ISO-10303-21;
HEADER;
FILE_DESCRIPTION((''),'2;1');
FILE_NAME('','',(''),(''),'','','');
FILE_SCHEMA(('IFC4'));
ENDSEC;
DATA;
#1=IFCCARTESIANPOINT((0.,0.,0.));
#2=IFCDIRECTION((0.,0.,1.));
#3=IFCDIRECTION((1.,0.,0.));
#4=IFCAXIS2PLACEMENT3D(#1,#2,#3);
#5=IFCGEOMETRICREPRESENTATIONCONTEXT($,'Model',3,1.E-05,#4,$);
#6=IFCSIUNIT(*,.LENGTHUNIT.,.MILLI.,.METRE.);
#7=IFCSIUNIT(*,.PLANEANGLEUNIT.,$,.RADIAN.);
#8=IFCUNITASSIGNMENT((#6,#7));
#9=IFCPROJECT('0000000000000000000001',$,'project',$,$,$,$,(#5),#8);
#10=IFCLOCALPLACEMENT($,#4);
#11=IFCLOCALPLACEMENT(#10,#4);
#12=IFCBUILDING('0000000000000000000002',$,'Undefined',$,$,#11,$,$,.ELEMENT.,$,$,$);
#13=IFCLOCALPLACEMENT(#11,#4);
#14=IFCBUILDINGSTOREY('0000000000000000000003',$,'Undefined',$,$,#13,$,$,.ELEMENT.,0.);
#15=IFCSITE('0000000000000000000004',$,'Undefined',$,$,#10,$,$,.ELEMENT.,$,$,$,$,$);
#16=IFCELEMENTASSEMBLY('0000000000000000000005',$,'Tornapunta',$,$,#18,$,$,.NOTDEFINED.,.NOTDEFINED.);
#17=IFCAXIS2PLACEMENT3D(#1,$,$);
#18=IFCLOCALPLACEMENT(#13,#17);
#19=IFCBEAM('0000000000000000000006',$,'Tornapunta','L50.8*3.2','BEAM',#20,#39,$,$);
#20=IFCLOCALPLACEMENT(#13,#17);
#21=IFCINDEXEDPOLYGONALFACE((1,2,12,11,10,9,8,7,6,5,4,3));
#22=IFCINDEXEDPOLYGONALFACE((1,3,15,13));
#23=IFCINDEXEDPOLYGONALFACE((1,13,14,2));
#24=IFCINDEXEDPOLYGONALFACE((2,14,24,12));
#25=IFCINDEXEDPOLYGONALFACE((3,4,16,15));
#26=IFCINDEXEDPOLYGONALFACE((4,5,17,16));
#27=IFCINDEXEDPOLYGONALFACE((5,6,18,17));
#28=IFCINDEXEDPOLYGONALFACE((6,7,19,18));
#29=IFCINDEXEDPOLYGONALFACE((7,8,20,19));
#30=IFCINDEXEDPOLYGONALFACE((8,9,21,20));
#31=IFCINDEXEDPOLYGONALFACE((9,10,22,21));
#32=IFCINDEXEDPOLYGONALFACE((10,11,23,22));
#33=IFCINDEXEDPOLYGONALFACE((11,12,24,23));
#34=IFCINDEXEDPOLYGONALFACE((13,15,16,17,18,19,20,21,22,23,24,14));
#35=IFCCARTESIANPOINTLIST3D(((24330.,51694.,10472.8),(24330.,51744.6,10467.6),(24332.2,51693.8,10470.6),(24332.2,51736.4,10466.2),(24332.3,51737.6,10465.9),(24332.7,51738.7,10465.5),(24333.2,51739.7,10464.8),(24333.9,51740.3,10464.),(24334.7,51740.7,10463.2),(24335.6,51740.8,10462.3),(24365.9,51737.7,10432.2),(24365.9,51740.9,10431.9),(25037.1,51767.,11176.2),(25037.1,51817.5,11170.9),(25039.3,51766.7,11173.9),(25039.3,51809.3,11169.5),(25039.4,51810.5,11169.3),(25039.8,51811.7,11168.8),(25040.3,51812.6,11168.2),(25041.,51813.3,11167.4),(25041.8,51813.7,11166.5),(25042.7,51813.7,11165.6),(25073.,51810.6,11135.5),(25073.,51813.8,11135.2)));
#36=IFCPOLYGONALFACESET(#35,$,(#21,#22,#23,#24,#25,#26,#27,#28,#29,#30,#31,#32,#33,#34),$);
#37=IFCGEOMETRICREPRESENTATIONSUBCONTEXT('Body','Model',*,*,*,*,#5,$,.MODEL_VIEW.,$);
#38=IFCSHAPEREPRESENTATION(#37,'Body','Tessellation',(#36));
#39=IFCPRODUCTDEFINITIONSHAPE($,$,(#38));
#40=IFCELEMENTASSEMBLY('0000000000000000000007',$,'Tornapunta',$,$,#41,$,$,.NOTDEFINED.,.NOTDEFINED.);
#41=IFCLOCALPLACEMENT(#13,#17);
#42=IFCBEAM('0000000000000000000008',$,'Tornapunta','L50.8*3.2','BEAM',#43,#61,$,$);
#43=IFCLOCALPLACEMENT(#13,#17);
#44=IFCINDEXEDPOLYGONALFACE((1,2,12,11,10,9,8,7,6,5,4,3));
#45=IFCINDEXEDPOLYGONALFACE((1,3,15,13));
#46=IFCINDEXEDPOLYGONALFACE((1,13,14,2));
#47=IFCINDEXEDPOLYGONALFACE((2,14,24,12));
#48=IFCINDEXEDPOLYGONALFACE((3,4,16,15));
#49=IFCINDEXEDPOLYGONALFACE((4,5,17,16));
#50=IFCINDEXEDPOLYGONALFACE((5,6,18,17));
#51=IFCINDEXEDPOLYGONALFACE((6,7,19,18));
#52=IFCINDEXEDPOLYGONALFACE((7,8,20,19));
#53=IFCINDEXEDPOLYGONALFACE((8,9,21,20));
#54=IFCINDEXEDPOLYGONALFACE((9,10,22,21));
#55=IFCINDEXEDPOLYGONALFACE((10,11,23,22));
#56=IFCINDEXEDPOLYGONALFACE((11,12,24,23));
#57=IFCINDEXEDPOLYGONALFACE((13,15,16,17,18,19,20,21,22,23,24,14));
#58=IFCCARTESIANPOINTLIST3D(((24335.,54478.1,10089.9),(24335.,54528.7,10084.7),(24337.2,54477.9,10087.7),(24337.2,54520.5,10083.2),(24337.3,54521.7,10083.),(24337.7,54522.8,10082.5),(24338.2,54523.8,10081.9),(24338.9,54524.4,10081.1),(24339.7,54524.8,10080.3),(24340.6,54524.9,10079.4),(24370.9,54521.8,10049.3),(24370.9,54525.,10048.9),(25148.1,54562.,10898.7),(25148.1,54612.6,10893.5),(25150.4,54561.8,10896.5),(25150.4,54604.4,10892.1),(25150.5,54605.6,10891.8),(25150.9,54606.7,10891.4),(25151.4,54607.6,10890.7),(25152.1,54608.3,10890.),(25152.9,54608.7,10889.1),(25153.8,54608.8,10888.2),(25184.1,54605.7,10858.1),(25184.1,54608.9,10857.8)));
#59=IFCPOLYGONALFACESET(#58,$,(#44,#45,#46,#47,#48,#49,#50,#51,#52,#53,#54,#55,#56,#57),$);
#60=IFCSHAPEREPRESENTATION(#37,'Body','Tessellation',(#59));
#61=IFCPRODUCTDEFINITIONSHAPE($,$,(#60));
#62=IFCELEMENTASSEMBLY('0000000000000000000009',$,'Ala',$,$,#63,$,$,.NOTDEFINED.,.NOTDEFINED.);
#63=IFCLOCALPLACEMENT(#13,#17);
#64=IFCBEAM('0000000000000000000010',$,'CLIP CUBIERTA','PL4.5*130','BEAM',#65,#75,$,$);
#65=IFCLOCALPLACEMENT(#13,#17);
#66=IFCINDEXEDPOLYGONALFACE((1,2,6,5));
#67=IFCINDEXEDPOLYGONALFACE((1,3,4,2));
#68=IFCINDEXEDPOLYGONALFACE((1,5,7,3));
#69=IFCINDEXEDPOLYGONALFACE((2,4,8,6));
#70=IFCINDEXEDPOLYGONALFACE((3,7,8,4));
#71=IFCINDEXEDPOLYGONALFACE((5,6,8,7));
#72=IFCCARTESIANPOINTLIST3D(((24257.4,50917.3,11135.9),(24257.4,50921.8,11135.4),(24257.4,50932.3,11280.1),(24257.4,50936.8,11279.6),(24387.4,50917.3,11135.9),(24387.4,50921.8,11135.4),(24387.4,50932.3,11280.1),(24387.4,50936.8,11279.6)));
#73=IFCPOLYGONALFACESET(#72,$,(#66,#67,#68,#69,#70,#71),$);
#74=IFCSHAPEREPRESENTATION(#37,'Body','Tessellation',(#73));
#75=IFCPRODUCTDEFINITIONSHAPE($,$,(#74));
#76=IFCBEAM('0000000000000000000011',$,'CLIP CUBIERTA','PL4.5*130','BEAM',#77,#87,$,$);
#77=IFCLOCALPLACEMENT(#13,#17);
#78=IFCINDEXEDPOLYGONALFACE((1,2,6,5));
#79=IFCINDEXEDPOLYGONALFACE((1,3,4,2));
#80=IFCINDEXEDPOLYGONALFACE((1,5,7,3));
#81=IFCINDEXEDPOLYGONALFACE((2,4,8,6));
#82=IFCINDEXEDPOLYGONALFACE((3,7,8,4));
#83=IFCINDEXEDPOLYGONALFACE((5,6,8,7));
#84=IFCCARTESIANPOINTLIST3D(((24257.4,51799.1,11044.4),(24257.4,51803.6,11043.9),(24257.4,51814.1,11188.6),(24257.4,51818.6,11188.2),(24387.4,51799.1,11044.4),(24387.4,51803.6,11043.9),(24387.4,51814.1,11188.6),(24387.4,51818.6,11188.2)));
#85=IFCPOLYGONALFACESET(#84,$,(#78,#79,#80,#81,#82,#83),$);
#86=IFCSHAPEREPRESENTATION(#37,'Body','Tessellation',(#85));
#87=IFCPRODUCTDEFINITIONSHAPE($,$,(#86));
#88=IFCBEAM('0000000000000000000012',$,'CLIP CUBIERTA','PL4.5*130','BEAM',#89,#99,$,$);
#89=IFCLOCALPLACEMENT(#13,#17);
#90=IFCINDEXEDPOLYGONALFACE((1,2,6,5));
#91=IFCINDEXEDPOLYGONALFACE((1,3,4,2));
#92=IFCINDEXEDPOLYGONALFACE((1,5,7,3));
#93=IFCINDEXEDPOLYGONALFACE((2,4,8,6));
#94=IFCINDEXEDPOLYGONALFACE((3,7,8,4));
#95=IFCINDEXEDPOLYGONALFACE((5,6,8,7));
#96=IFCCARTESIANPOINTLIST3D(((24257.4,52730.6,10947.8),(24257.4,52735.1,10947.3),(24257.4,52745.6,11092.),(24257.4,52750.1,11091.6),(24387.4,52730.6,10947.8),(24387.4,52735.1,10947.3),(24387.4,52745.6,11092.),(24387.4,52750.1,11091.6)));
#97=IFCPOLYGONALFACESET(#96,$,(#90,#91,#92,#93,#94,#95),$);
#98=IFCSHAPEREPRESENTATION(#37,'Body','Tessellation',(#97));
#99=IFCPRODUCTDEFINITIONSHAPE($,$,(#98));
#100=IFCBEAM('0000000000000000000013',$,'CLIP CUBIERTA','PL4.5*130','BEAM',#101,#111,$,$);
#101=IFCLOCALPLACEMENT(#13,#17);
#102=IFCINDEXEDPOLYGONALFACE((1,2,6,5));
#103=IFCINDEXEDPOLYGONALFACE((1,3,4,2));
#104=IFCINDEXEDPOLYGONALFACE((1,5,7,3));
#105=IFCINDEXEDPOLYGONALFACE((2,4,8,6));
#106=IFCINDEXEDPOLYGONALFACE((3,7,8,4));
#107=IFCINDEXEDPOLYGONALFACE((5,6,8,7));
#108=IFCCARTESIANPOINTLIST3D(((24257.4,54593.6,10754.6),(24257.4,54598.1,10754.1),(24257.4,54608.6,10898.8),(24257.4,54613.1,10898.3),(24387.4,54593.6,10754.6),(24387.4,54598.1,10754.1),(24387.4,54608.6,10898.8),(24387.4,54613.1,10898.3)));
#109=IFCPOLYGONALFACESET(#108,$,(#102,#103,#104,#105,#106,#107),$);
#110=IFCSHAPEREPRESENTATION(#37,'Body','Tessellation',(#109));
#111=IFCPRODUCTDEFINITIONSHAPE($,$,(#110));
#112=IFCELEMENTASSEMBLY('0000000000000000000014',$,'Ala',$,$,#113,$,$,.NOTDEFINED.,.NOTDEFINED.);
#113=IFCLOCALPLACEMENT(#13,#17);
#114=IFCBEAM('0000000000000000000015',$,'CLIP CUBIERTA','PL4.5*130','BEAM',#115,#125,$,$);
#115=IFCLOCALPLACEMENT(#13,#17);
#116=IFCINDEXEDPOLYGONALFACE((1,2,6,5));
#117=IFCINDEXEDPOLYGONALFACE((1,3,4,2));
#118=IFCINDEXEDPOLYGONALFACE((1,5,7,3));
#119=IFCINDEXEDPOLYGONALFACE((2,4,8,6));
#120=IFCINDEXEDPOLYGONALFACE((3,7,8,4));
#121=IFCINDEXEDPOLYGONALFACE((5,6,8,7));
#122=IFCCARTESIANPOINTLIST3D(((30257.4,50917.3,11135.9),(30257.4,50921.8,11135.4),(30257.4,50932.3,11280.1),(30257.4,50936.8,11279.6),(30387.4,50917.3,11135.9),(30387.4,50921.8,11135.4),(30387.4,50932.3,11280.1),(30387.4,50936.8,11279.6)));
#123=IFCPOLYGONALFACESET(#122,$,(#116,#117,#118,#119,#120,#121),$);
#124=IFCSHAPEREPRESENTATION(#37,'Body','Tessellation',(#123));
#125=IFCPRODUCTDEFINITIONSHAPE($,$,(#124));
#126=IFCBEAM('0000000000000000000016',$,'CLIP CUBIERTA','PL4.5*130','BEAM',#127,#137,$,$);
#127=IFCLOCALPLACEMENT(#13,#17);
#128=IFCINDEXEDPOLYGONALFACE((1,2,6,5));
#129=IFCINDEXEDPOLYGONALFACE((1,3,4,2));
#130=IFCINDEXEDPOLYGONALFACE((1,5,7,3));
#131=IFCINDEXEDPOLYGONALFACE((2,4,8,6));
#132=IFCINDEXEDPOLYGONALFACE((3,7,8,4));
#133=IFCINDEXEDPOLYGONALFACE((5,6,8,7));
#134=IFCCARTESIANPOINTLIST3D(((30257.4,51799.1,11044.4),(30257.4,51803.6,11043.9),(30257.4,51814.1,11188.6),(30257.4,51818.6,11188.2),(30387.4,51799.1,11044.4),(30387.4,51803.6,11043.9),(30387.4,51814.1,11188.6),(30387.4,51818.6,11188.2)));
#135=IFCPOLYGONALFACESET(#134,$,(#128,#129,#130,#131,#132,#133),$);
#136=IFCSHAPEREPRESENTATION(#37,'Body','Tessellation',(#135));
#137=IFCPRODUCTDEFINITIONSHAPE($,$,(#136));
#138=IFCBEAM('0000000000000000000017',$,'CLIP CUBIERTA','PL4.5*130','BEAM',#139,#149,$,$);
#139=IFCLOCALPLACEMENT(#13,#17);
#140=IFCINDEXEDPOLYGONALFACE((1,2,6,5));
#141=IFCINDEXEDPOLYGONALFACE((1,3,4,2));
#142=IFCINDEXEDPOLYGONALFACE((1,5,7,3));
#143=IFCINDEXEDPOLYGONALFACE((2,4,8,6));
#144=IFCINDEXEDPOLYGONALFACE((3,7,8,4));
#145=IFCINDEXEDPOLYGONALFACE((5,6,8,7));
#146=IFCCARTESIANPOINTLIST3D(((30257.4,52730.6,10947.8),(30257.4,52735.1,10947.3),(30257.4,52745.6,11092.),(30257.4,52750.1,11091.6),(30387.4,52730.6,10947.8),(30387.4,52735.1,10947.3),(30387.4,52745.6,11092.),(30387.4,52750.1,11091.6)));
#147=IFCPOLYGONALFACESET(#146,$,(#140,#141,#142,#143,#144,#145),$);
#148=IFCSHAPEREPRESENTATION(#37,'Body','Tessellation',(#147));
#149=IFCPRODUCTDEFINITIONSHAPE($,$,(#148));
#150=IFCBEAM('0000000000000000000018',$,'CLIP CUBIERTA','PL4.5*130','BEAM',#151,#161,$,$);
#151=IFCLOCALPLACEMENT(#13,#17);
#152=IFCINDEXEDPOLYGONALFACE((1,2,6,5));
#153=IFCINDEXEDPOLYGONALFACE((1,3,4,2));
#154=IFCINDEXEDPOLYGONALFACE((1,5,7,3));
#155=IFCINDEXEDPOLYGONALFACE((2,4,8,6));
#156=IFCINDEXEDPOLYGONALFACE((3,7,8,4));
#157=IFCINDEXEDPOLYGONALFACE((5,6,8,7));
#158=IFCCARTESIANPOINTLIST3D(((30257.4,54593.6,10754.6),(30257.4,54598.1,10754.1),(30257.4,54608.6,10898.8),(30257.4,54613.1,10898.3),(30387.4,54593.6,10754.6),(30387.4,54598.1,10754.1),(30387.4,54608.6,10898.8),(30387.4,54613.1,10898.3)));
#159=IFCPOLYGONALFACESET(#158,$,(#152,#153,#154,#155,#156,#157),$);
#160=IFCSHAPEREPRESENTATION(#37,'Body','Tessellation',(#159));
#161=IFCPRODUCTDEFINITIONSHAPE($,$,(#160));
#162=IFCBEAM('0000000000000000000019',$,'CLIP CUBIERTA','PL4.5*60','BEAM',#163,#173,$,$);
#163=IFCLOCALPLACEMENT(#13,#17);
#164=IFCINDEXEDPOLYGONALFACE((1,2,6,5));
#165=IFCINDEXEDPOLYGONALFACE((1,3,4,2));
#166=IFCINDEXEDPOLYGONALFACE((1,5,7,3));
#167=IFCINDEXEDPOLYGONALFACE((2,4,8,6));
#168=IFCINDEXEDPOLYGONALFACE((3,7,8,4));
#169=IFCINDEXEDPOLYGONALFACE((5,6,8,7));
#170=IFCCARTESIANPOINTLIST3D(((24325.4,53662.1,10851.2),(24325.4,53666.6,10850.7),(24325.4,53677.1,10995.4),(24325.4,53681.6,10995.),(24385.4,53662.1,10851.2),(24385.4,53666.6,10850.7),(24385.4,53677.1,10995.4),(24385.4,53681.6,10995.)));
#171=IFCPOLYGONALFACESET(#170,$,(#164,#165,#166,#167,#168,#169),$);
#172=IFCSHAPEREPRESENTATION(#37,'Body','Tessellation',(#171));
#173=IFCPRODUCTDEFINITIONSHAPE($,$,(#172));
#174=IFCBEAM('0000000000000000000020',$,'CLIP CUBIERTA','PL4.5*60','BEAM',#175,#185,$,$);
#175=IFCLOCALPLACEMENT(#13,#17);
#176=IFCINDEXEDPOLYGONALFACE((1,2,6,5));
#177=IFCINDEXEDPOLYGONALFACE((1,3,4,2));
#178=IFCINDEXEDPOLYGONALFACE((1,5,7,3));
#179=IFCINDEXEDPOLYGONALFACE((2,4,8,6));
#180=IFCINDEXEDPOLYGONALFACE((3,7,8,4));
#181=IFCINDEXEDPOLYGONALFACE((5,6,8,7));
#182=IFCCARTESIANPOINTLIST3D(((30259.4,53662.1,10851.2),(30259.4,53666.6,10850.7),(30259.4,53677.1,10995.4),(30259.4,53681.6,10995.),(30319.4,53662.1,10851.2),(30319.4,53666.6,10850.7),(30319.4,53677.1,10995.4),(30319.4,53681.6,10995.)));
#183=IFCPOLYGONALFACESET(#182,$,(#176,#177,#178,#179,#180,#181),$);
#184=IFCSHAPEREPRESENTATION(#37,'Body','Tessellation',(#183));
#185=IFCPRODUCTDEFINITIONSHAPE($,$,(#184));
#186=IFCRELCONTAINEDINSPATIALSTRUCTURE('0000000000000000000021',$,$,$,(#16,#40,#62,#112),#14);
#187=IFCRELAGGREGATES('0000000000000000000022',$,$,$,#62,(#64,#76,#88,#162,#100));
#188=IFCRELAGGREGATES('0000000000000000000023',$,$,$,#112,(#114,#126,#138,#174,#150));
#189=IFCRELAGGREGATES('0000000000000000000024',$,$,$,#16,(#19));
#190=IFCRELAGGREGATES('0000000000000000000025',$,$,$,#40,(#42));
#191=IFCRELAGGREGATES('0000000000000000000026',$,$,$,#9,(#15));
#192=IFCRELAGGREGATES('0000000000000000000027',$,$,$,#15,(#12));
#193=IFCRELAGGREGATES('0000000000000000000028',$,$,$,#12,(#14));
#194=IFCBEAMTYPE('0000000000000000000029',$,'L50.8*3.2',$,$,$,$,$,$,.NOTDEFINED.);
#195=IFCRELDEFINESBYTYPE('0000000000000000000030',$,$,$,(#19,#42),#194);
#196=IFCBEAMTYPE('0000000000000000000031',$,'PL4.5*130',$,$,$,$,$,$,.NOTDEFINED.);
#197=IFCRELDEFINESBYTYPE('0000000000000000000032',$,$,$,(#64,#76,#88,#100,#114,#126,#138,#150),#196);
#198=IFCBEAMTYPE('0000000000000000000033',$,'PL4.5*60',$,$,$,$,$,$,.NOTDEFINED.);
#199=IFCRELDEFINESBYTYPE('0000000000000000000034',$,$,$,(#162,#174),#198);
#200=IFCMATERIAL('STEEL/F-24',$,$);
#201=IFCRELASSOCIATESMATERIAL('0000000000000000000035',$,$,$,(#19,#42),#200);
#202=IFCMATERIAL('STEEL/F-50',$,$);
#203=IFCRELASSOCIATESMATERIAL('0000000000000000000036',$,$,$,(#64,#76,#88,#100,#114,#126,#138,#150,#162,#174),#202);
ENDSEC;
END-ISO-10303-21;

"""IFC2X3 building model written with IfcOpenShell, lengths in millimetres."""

from ifc_helpers import new_model, si_unit, frame, origin_with_axes, origin_2d_with_axis, place, context, subcontext, project, spatial, rectangle, l_section, extrude, material, type_object, element, aggregate, save


model = new_model("IFC2X3")

# Units and contexts
model_context = context("Model", 3, precision=1e-05, world=origin_with_axes())
body_context = subcontext(model_context, "Body", "Model", "MODEL_VIEW")
ifc_project = project(units=[si_unit("LENGTHUNIT", "METRE", prefix="MILLI"), si_unit("PLANEANGLEUNIT", "RADIAN")], contexts=[model_context])

# Site, building, storey
site_placement = place(None, origin_with_axes())
site = spatial("IfcSite", under=ifc_project, at=site_placement, Name="Undefined", CompositionType="ELEMENT")
building_placement = place(site_placement, origin_with_axes())
building = spatial("IfcBuilding", under=site, at=building_placement, Name="Undefined", CompositionType="ELEMENT")
storey_placement = place(building_placement, origin_with_axes())
storey = spatial("IfcBuildingStorey", under=building, at=storey_placement, Name="Undefined", CompositionType="ELEMENT", Elevation=0.0)

# Element assemblies, beams
assembly_1_placement = place(storey_placement, origin_with_axes())
assembly_1 = element("IfcElementAssembly", 1, at=assembly_1_placement, inside=storey, Name="Tornapunta", AssemblyPlace="NOTDEFINED", PredefinedType="NOTDEFINED")
ifc_material_1 = material(Name="STEEL/F-24")
beam_type_1 = type_object("IfcBeamType", Name="L50.8*3.2", PredefinedType="NOTDEFINED")
beam_1_placement = place(assembly_1_placement, frame((25055.0, 51790.4, 11155.7), z_axis=(0.707105, -0.072943, -0.703336), x_axis=(-0.707108, -0.072942, -0.703333)))
beam_1 = element("IfcBeam", 2, at=beam_1_placement, type_object=beam_type_1, material=ifc_material_1, Name="Tornapunta", Description="L50.8*3.2", ObjectType="BEAM", context=body_context, shape_type="SweptSolid", body=[
    extrude(l_section(Depth=50.8, Width=50.8, Thickness=3.2, FilletRadius=4.8, at=origin_2d_with_axis()), frame((1000.0, 0.0, 0.0), z_axis=(-1.0, 0.0, 0.0), x_axis=(0.0, -1.0, 0.0)), (0.0, 0.0, 1.0), 1000.0),
])
assembly_2_placement = place(storey_placement, origin_with_axes())
assembly_2 = element("IfcElementAssembly", 3, at=assembly_2_placement, inside=storey, Name="Tornapunta", AssemblyPlace="NOTDEFINED", PredefinedType="NOTDEFINED")
beam_2_placement = place(assembly_2_placement, frame((25166.1, 54585.4, 10878.3), z_axis=(0.707104, -0.07295, -0.703337), x_axis=(-0.70711, -0.07295, -0.703331)))
beam_2 = element("IfcBeam", 4, at=beam_2_placement, type_object=beam_type_1, material=ifc_material_1, Name="Tornapunta", Description="L50.8*3.2", ObjectType="BEAM", context=body_context, shape_type="SweptSolid", body=[
    extrude(l_section(Depth=50.8, Width=50.8, Thickness=3.2, FilletRadius=4.8, at=origin_2d_with_axis()), frame((1150.0, 0.0, 0.0), z_axis=(-1.0, 0.0, 0.0), x_axis=(0.0, -1.0, 0.0)), (0.0, 0.0, 1.0), 1150.0),
])

# Element assemblies, beams
assembly_3_placement = place(storey_placement, origin_with_axes())
assembly_3 = element("IfcElementAssembly", 5, at=assembly_3_placement, inside=storey, Name="Ala", AssemblyPlace="NOTDEFINED", PredefinedType="NOTDEFINED")
ifc_material_2 = material(Name="STEEL/F-50")
beam_type_2 = type_object("IfcBeamType", Name="PL4.5*130", PredefinedType="NOTDEFINED")
beam_3_placement = place(assembly_3_placement, frame((24322.4, 50919.6, 11135.6), z_axis=(-1.0, 0.0, 0.0), x_axis=(0.0, 0.103162, 0.994665)))
beam_3 = element("IfcBeam", 6, at=beam_3_placement, type_object=beam_type_2, material=ifc_material_2, Name="CLIP CUBIERTA", Description="PL4.5*130", ObjectType="BEAM", context=body_context, shape_type="SweptSolid", body=[
    extrude(rectangle(XDim=4.5, YDim=130.0, at=origin_2d_with_axis()), frame((145.0, 0.0, 0.0), z_axis=(-1.0, 0.0, 0.0), x_axis=(0.0, -1.0, 0.0)), (0.0, 0.0, 1.0), 145.0),
])
beam_4_placement = place(assembly_3_placement, frame((24322.4, 51801.4, 11044.2), z_axis=(-1.0, 0.0, 0.0), x_axis=(0.0, 0.103162, 0.994665)))
beam_4 = element("IfcBeam", 7, at=beam_4_placement, type_object=beam_type_2, material=ifc_material_2, Name="CLIP CUBIERTA", Description="PL4.5*130", ObjectType="BEAM", context=body_context, shape_type="SweptSolid", body=[
    extrude(rectangle(XDim=4.5, YDim=130.0, at=origin_2d_with_axis()), frame((145.0, 0.0, 0.0), z_axis=(-1.0, 0.0, 0.0), x_axis=(0.0, -1.0, 0.0)), (0.0, 0.0, 1.0), 145.0),
])
beam_5_placement = place(assembly_3_placement, frame((24322.4, 52732.9, 10947.6), z_axis=(-1.0, 0.0, 0.0), x_axis=(0.0, 0.103162, 0.994665)))
beam_5 = element("IfcBeam", 8, at=beam_5_placement, type_object=beam_type_2, material=ifc_material_2, Name="CLIP CUBIERTA", Description="PL4.5*130", ObjectType="BEAM", context=body_context, shape_type="SweptSolid", body=[
    extrude(rectangle(XDim=4.5, YDim=130.0, at=origin_2d_with_axis()), frame((145.0, 0.0, 0.0), z_axis=(-1.0, 0.0, 0.0), x_axis=(0.0, -1.0, 0.0)), (0.0, 0.0, 1.0), 145.0),
])
beam_6_placement = place(assembly_3_placement, frame((24322.4, 54595.9, 10754.3), z_axis=(-1.0, 0.0, 0.0), x_axis=(0.0, 0.103162, 0.994665)))
beam_6 = element("IfcBeam", 9, at=beam_6_placement, type_object=beam_type_2, material=ifc_material_2, Name="CLIP CUBIERTA", Description="PL4.5*130", ObjectType="BEAM", context=body_context, shape_type="SweptSolid", body=[
    extrude(rectangle(XDim=4.5, YDim=130.0, at=origin_2d_with_axis()), frame((145.0, 0.0, 0.0), z_axis=(-1.0, 0.0, 0.0), x_axis=(0.0, -1.0, 0.0)), (0.0, 0.0, 1.0), 145.0),
])
assembly_4_placement = place(storey_placement, origin_with_axes())
assembly_4 = element("IfcElementAssembly", 10, at=assembly_4_placement, inside=storey, Name="Ala", AssemblyPlace="NOTDEFINED", PredefinedType="NOTDEFINED")
beam_7_placement = place(assembly_4_placement, frame((30322.4, 50919.6, 11135.6), z_axis=(-1.0, 0.0, 0.0), x_axis=(0.0, 0.103162, 0.994665)))
beam_7 = element("IfcBeam", 11, at=beam_7_placement, type_object=beam_type_2, material=ifc_material_2, Name="CLIP CUBIERTA", Description="PL4.5*130", ObjectType="BEAM", context=body_context, shape_type="SweptSolid", body=[
    extrude(rectangle(XDim=4.5, YDim=130.0, at=origin_2d_with_axis()), frame((145.0, 0.0, 0.0), z_axis=(-1.0, 0.0, 0.0), x_axis=(0.0, -1.0, 0.0)), (0.0, 0.0, 1.0), 145.0),
])
beam_8_placement = place(assembly_4_placement, frame((30322.4, 51801.4, 11044.2), z_axis=(-1.0, 0.0, 0.0), x_axis=(0.0, 0.103162, 0.994665)))
beam_8 = element("IfcBeam", 12, at=beam_8_placement, type_object=beam_type_2, material=ifc_material_2, Name="CLIP CUBIERTA", Description="PL4.5*130", ObjectType="BEAM", context=body_context, shape_type="SweptSolid", body=[
    extrude(rectangle(XDim=4.5, YDim=130.0, at=origin_2d_with_axis()), frame((145.0, 0.0, 0.0), z_axis=(-1.0, 0.0, 0.0), x_axis=(0.0, -1.0, 0.0)), (0.0, 0.0, 1.0), 145.0),
])
beam_9_placement = place(assembly_4_placement, frame((30322.4, 52732.9, 10947.6), z_axis=(-1.0, 0.0, 0.0), x_axis=(0.0, 0.103162, 0.994665)))
beam_9 = element("IfcBeam", 13, at=beam_9_placement, type_object=beam_type_2, material=ifc_material_2, Name="CLIP CUBIERTA", Description="PL4.5*130", ObjectType="BEAM", context=body_context, shape_type="SweptSolid", body=[
    extrude(rectangle(XDim=4.5, YDim=130.0, at=origin_2d_with_axis()), frame((145.0, 0.0, 0.0), z_axis=(-1.0, 0.0, 0.0), x_axis=(0.0, -1.0, 0.0)), (0.0, 0.0, 1.0), 145.0),
])
beam_10_placement = place(assembly_4_placement, frame((30322.4, 54595.9, 10754.3), z_axis=(-1.0, 0.0, 0.0), x_axis=(0.0, 0.103162, 0.994665)))
beam_10 = element("IfcBeam", 14, at=beam_10_placement, type_object=beam_type_2, material=ifc_material_2, Name="CLIP CUBIERTA", Description="PL4.5*130", ObjectType="BEAM", context=body_context, shape_type="SweptSolid", body=[
    extrude(rectangle(XDim=4.5, YDim=130.0, at=origin_2d_with_axis()), frame((145.0, 0.0, 0.0), z_axis=(-1.0, 0.0, 0.0), x_axis=(0.0, -1.0, 0.0)), (0.0, 0.0, 1.0), 145.0),
])

# Beams
beam_type_3 = type_object("IfcBeamType", Name="PL4.5*60", PredefinedType="NOTDEFINED")
beam_11_placement = place(assembly_3_placement, frame((24355.4, 53664.4, 10851.0), z_axis=(1.0, 0.0, 0.0), x_axis=(0.0, 0.103162, 0.994665)))
beam_11 = element("IfcBeam", 15, at=beam_11_placement, type_object=beam_type_3, material=ifc_material_2, Name="CLIP CUBIERTA", Description="PL4.5*60", ObjectType="BEAM", context=body_context, shape_type="SweptSolid", body=[
    extrude(rectangle(XDim=4.5, YDim=60.0, at=origin_2d_with_axis()), frame((145.0, 0.0, 0.0), z_axis=(-1.0, 0.0, 0.0), x_axis=(0.0, -1.0, 0.0)), (0.0, 0.0, 1.0), 145.0),
])
beam_12_placement = place(assembly_4_placement, frame((30289.4, 53664.4, 10851.0), z_axis=(-1.0, 0.0, 0.0), x_axis=(0.0, 0.103162, 0.994665)))
beam_12 = element("IfcBeam", 16, at=beam_12_placement, type_object=beam_type_3, material=ifc_material_2, Name="CLIP CUBIERTA", Description="PL4.5*60", ObjectType="BEAM", context=body_context, shape_type="SweptSolid", body=[
    extrude(rectangle(XDim=4.5, YDim=60.0, at=origin_2d_with_axis()), frame((145.0, 0.0, 0.0), z_axis=(-1.0, 0.0, 0.0), x_axis=(0.0, -1.0, 0.0)), (0.0, 0.0, 1.0), 145.0),
])

aggregate(assembly_3, [beam_3, beam_4, beam_5, beam_11, beam_6])

aggregate(assembly_4, [beam_7, beam_8, beam_9, beam_12, beam_10])

aggregate(assembly_1, [beam_1])
aggregate(assembly_2, [beam_2])

save(model, "model.ifc")
